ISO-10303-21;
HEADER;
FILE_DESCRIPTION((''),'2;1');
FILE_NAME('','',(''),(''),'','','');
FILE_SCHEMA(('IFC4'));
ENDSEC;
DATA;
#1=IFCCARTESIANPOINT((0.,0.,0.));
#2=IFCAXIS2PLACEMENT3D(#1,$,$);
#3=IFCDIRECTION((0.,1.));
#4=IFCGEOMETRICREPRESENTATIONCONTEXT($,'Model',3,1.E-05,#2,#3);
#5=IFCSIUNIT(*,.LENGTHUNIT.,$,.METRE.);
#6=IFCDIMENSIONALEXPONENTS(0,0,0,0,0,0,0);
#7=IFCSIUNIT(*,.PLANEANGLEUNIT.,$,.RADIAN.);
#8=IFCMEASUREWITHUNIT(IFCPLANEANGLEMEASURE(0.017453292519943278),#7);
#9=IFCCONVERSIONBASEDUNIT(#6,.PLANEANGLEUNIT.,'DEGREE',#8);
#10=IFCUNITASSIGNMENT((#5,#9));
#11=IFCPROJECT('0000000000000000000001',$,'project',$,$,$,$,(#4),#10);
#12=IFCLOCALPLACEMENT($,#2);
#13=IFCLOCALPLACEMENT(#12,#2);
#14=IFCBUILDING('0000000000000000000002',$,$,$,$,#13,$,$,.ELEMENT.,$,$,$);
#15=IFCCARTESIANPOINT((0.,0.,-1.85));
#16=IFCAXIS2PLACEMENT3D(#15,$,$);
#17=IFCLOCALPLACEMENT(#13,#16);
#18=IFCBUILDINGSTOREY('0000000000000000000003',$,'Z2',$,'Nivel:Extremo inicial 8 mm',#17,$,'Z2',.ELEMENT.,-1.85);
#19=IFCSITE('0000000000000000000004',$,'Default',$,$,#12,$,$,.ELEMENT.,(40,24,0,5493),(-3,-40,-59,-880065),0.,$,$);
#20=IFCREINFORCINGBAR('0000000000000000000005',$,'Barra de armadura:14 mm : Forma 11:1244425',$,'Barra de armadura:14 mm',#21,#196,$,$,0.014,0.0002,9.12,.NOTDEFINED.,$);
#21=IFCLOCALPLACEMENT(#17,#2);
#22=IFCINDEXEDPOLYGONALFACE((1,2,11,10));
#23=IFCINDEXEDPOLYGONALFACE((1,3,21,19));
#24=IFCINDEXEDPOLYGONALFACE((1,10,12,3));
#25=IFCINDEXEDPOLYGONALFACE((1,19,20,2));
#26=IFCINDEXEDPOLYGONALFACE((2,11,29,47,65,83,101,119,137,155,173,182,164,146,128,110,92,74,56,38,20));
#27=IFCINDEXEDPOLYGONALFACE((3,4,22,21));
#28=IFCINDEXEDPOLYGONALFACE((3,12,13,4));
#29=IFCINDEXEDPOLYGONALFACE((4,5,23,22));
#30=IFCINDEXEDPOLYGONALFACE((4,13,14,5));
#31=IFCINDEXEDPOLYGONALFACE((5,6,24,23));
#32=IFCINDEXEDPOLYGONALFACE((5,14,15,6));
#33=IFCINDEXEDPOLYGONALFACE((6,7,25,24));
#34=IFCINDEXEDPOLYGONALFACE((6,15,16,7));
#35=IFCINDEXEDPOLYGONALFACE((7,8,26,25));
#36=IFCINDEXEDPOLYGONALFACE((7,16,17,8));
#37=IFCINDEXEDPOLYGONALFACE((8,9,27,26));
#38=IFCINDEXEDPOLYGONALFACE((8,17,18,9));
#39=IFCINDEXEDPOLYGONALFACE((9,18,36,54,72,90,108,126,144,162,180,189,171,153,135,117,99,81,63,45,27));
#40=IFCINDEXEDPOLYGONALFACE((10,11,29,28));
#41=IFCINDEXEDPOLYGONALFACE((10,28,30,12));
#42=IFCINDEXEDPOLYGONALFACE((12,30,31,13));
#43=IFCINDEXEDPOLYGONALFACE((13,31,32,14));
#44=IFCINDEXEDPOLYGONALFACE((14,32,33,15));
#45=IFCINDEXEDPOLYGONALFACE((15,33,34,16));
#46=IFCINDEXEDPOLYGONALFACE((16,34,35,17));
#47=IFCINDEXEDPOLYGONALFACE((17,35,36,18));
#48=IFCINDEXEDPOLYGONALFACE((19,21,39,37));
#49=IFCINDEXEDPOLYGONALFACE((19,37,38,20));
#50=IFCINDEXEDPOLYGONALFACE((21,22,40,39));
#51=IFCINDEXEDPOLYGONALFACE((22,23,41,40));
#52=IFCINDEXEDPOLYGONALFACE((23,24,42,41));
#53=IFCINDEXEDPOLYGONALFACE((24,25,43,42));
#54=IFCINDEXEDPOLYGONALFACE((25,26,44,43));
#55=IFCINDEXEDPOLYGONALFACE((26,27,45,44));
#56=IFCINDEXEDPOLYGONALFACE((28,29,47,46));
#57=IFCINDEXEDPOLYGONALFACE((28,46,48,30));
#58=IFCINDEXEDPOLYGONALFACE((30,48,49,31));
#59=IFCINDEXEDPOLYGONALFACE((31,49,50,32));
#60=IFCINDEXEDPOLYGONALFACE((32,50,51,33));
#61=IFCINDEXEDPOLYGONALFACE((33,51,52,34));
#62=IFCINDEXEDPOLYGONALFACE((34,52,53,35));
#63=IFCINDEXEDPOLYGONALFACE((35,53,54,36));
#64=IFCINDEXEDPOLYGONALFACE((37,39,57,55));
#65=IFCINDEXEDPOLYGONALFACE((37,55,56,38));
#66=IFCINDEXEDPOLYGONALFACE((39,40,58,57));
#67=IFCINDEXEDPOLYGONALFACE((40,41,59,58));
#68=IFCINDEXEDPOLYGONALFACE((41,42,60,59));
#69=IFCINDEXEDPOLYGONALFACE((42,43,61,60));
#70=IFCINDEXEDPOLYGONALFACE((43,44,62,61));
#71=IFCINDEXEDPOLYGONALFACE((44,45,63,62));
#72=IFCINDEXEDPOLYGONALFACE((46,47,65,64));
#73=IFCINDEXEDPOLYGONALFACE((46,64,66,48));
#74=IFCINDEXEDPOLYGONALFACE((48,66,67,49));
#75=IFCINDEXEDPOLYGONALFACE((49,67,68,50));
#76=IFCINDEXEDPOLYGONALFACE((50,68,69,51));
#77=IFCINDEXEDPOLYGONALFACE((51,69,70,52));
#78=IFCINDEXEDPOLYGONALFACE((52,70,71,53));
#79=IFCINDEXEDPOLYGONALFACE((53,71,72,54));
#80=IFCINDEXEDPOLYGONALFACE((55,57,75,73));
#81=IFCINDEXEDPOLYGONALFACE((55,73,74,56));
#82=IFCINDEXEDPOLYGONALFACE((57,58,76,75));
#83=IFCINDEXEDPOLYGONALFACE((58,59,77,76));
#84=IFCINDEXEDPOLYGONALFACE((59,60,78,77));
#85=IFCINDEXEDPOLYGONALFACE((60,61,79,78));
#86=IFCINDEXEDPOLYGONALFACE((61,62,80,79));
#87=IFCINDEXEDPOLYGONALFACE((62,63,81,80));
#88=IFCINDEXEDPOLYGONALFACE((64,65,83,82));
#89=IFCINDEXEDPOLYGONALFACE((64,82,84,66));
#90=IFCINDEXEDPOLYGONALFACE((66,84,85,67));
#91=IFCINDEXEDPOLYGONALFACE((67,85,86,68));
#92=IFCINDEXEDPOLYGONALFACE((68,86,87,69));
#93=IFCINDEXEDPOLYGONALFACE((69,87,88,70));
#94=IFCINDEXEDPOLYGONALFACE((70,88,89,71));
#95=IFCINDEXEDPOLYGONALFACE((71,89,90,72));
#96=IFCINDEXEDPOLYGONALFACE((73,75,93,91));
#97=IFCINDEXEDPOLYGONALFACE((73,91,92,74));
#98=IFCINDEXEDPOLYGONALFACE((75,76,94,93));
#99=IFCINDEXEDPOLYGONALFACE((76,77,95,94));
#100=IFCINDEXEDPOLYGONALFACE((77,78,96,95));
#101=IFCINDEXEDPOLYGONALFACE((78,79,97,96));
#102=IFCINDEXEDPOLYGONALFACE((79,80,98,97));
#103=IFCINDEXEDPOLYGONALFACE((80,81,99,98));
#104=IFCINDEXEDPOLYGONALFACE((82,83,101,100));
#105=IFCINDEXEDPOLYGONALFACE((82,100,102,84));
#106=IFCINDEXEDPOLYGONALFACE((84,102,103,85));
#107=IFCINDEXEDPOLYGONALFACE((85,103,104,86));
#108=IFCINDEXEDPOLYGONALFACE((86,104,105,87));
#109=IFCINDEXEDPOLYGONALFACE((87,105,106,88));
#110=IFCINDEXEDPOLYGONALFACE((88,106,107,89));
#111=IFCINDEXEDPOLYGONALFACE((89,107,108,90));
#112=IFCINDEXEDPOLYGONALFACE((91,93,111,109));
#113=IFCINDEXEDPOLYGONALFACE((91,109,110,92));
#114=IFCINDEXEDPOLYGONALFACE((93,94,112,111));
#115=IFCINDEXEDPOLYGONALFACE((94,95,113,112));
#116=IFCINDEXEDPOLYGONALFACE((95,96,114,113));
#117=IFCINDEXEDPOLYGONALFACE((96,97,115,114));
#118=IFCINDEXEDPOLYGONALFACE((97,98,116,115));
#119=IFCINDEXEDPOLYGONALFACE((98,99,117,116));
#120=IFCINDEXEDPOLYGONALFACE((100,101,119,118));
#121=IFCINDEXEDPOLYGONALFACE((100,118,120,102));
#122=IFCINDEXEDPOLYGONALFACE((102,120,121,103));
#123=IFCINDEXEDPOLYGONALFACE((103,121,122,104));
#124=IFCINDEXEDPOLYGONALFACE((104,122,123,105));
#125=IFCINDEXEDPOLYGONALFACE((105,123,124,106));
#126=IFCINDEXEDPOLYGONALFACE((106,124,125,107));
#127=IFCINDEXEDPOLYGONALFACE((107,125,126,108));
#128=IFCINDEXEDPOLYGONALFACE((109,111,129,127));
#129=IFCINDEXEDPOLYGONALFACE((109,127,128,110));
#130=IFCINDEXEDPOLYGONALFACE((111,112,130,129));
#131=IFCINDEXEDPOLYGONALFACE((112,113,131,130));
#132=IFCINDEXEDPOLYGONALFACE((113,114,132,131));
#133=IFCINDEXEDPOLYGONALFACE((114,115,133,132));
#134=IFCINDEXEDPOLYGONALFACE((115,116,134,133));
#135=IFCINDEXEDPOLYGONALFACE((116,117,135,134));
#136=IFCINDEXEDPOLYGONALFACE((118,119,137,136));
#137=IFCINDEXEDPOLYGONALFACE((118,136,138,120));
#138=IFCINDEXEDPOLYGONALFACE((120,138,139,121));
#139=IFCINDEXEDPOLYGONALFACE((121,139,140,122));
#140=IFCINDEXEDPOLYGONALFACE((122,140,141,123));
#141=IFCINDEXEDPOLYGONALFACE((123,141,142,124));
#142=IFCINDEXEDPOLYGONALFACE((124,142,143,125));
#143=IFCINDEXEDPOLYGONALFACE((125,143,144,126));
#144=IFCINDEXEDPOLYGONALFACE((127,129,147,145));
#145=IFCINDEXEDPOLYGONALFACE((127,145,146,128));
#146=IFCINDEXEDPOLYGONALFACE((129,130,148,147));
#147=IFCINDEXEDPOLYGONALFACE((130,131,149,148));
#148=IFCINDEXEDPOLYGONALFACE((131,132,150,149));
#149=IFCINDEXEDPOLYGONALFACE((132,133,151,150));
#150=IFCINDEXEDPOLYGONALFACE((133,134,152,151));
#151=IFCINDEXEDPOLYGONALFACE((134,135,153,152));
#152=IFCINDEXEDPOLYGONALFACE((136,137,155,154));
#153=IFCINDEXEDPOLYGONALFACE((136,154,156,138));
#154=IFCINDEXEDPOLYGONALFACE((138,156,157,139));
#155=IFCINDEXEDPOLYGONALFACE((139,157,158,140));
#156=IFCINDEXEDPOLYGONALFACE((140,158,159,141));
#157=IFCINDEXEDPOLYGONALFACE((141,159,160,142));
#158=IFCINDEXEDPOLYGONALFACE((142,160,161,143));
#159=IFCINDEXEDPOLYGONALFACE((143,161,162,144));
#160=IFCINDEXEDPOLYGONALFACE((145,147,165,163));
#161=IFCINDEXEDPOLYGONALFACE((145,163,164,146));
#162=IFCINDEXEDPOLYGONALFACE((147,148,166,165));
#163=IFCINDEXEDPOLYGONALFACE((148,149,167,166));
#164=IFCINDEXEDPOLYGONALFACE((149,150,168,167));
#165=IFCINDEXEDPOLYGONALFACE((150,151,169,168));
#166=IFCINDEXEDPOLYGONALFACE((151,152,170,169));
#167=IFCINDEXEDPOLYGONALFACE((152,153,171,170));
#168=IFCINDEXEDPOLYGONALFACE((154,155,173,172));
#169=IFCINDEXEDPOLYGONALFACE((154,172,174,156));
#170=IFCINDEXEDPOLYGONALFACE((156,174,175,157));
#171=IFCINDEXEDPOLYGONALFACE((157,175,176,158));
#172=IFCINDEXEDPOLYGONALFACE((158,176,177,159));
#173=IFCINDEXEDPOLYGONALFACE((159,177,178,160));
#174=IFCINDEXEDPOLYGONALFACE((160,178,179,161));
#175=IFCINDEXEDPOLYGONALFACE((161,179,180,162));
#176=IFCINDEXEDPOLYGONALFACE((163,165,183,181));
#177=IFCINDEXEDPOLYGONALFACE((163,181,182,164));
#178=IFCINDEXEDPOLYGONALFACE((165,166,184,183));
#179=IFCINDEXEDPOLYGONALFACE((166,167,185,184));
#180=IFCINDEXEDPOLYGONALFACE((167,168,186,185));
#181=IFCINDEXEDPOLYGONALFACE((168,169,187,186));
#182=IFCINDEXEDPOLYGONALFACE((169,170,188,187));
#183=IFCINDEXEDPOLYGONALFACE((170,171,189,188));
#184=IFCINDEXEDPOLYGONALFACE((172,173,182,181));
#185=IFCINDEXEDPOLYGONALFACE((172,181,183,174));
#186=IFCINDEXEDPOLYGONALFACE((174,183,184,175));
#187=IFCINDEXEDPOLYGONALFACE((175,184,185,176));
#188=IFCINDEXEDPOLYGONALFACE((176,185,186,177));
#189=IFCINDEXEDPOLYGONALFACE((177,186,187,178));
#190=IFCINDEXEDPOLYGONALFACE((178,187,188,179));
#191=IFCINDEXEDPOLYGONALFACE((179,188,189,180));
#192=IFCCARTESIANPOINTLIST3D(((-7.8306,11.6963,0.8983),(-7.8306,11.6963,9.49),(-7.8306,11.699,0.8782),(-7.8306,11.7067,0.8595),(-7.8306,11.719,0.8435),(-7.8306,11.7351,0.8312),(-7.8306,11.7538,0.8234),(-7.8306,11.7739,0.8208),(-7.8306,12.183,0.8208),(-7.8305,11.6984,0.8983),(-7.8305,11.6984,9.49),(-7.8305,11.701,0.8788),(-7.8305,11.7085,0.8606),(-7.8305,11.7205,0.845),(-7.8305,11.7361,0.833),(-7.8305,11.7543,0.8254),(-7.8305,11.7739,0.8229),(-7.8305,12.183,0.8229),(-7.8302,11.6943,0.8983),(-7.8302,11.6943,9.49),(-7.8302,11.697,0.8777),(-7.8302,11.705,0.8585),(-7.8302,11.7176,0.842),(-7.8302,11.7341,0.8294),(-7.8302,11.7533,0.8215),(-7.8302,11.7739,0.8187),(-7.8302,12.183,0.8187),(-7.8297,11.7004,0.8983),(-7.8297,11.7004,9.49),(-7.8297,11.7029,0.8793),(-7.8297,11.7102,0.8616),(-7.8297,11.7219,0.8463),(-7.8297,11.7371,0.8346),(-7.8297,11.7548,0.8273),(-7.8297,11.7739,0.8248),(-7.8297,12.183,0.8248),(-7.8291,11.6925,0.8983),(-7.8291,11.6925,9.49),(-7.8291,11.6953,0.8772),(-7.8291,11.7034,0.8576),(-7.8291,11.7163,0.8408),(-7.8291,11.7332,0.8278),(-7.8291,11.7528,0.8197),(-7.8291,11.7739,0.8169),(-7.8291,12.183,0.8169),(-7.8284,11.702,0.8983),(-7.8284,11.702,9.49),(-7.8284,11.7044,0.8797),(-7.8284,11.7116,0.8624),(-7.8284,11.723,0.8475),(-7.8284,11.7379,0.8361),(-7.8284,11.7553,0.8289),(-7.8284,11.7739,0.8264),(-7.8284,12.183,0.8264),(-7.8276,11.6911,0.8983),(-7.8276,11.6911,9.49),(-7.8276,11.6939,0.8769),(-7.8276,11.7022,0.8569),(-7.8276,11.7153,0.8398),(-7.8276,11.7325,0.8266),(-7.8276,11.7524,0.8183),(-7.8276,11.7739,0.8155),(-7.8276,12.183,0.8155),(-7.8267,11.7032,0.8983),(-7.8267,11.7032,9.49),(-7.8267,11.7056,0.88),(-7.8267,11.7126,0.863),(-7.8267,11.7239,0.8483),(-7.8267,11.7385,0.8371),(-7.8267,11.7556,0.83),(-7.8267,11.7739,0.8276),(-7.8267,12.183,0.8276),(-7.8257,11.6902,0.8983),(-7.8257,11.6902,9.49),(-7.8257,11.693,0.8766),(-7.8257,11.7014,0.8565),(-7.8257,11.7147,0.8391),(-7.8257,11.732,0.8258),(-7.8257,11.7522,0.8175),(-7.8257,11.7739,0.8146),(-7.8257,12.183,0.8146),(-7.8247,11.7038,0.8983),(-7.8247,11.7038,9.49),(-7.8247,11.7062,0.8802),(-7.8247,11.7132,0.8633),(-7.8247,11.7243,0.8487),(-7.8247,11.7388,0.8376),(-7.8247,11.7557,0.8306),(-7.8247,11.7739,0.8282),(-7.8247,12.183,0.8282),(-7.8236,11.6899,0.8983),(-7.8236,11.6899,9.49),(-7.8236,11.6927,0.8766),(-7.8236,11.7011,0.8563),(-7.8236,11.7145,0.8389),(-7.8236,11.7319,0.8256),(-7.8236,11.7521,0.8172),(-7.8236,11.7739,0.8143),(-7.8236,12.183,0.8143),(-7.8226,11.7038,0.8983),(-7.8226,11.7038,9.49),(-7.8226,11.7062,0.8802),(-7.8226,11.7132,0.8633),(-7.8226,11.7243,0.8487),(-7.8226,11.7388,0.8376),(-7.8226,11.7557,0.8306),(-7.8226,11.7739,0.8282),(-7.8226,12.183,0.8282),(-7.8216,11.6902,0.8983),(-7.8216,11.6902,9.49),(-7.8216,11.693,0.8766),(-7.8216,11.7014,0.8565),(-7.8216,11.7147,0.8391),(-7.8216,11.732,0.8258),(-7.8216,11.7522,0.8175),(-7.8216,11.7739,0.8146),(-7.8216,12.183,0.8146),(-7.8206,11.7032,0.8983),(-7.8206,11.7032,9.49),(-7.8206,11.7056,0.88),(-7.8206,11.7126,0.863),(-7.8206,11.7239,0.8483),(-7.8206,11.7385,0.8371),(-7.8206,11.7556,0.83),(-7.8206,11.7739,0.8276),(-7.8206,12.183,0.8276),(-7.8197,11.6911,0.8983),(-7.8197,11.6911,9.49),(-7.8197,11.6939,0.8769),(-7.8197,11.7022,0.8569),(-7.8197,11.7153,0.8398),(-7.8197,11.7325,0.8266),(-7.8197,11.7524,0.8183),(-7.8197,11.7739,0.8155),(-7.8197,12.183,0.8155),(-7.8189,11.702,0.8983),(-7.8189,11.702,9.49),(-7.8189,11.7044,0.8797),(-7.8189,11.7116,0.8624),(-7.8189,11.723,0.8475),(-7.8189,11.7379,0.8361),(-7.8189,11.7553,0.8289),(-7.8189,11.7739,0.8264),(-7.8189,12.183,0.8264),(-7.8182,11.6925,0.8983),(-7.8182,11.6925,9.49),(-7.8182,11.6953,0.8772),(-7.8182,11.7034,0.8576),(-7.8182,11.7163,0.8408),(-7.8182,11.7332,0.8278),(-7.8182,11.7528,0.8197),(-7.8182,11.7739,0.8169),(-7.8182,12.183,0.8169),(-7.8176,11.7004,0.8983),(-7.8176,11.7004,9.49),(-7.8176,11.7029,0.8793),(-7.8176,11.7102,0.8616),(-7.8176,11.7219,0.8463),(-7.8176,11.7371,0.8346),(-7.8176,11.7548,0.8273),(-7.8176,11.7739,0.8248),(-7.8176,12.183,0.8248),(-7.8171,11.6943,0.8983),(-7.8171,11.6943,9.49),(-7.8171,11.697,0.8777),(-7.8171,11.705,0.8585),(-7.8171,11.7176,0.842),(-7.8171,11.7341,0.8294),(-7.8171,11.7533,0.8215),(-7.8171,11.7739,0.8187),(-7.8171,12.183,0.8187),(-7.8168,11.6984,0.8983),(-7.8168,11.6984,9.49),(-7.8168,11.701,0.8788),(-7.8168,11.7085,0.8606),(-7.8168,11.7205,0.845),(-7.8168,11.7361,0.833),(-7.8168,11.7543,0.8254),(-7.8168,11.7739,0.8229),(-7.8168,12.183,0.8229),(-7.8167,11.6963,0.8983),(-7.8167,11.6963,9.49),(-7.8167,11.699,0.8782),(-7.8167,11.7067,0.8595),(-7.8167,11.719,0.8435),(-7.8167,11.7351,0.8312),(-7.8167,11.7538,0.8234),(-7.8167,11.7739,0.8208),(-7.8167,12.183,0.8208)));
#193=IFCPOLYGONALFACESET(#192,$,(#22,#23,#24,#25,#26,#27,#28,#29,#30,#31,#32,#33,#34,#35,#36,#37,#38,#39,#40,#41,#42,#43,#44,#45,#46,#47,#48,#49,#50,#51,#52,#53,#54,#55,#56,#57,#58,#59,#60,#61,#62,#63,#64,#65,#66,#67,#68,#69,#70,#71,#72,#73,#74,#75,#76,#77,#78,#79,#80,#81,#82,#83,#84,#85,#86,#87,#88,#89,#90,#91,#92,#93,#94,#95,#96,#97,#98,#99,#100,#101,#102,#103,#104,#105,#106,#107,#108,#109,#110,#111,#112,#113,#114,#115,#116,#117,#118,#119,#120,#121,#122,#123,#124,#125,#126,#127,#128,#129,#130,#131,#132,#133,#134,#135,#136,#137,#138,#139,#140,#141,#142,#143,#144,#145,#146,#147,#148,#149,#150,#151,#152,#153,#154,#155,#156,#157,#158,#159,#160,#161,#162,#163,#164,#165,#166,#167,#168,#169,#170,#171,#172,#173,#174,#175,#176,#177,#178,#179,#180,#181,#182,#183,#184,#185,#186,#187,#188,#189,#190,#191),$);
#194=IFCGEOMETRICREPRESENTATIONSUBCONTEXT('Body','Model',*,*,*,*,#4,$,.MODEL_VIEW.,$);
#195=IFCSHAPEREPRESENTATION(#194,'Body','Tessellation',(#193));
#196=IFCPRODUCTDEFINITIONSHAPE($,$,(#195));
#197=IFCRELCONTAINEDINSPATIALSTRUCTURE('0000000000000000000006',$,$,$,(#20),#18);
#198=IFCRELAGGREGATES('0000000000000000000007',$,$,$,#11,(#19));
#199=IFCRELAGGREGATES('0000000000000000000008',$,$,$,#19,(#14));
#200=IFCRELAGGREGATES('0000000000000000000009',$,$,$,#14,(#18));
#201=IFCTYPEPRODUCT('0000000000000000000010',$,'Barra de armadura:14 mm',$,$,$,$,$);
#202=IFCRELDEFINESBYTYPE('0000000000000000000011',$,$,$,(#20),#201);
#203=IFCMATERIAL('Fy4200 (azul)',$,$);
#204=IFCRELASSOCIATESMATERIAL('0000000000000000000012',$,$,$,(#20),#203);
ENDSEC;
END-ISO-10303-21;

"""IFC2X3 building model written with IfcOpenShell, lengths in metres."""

from ifc_helpers import new_model, entity, si_unit, converted_unit, direction, frame, origin, place, context, subcontext, project, spatial, material, type_object, element, save


model = new_model("IFC2X3")

# Units and contexts
model_context = context("Model", 3, precision=1e-05, world=origin(), true_north=direction((0.0, 1.0)))
body_context = subcontext(model_context, "Body", "Model", "MODEL_VIEW")
ifc_project = project(units=[si_unit("LENGTHUNIT", "METRE"), converted_unit("PLANEANGLEUNIT", "DEGREE", entity("IfcPlaneAngleMeasure", 0.017453292519943278), si_unit("PLANEANGLEUNIT", "RADIAN"), dimensions=[0, 0, 0, 0, 0, 0, 0])], contexts=[model_context])

# Site, building, storey
site_placement = place(None, origin())
site = spatial("IfcSite", under=ifc_project, at=site_placement, Name="Default", CompositionType="ELEMENT", RefLatitude=(40, 24, 0, 5493), RefLongitude=(-3, -40, -59, -880065), RefElevation=0.0)
building_placement = place(site_placement, origin())
building = spatial("IfcBuilding", under=site, at=building_placement, CompositionType="ELEMENT")
storey_placement = place(building_placement, frame((0.0, 0.0, -1.85)))
storey = spatial("IfcBuildingStorey", under=building, at=storey_placement, Name="Z2", ObjectType="Nivel:Extremo inicial 8 mm", LongName="Z2", CompositionType="ELEMENT", Elevation=-1.85)

# Reinforcing bar
ifc_material_1 = material(Name="Fy4200 (azul)")
type_product_1 = type_object("IfcTypeProduct", Name="Barra de armadura:14 mm")
reinforcing_bar_1_placement = place(storey_placement, origin())
element("IfcReinforcingBar", 1, at=reinforcing_bar_1_placement, inside=storey, type_object=type_product_1, material=ifc_material_1, Name="Barra de armadura:14 mm : Forma 11:1244425", ObjectType="Barra de armadura:14 mm", BarLength=9.12, BarRole="NOTDEFINED", CrossSectionArea=0.0002, NominalDiameter=0.014, context=body_context, shape_type="AdvancedSweptSolid", body=[
    entity("IfcSweptDiskSolid", entity("IfcCompositeCurve", [entity("IfcCompositeCurveSegment", "CONTINUOUS", True, entity("IfcPolyline", [entity("IfcCartesianPoint", [-7.8236, 11.6969, 9.49]), entity("IfcCartesianPoint", [-7.8236, 11.6969, 0.8983])])), entity("IfcCompositeCurveSegment", "CONTINUOUS", True, entity("IfcTrimmedCurve", entity("IfcCircle", entity("IfcAxis2Placement3D", entity("IfcCartesianPoint", [-7.8236, 11.7739, 0.8983]), entity("IfcDirection", [1.0, 0.0, 0.0]), entity("IfcDirection", [0.0, 0.0, -1.0])), 0.077), [entity("IfcParameterValue", 270.0)], [entity("IfcParameterValue", 360.0)], True, "PARAMETER")), entity("IfcCompositeCurveSegment", "CONTINUOUS", True, entity("IfcPolyline", [entity("IfcCartesianPoint", [-7.8236, 11.7739, 0.8213]), entity("IfcCartesianPoint", [-7.8236, 12.183, 0.8213])]))], False), 0.007, None, 0.0, 92.0),
])

save(model, "model.ifc")
